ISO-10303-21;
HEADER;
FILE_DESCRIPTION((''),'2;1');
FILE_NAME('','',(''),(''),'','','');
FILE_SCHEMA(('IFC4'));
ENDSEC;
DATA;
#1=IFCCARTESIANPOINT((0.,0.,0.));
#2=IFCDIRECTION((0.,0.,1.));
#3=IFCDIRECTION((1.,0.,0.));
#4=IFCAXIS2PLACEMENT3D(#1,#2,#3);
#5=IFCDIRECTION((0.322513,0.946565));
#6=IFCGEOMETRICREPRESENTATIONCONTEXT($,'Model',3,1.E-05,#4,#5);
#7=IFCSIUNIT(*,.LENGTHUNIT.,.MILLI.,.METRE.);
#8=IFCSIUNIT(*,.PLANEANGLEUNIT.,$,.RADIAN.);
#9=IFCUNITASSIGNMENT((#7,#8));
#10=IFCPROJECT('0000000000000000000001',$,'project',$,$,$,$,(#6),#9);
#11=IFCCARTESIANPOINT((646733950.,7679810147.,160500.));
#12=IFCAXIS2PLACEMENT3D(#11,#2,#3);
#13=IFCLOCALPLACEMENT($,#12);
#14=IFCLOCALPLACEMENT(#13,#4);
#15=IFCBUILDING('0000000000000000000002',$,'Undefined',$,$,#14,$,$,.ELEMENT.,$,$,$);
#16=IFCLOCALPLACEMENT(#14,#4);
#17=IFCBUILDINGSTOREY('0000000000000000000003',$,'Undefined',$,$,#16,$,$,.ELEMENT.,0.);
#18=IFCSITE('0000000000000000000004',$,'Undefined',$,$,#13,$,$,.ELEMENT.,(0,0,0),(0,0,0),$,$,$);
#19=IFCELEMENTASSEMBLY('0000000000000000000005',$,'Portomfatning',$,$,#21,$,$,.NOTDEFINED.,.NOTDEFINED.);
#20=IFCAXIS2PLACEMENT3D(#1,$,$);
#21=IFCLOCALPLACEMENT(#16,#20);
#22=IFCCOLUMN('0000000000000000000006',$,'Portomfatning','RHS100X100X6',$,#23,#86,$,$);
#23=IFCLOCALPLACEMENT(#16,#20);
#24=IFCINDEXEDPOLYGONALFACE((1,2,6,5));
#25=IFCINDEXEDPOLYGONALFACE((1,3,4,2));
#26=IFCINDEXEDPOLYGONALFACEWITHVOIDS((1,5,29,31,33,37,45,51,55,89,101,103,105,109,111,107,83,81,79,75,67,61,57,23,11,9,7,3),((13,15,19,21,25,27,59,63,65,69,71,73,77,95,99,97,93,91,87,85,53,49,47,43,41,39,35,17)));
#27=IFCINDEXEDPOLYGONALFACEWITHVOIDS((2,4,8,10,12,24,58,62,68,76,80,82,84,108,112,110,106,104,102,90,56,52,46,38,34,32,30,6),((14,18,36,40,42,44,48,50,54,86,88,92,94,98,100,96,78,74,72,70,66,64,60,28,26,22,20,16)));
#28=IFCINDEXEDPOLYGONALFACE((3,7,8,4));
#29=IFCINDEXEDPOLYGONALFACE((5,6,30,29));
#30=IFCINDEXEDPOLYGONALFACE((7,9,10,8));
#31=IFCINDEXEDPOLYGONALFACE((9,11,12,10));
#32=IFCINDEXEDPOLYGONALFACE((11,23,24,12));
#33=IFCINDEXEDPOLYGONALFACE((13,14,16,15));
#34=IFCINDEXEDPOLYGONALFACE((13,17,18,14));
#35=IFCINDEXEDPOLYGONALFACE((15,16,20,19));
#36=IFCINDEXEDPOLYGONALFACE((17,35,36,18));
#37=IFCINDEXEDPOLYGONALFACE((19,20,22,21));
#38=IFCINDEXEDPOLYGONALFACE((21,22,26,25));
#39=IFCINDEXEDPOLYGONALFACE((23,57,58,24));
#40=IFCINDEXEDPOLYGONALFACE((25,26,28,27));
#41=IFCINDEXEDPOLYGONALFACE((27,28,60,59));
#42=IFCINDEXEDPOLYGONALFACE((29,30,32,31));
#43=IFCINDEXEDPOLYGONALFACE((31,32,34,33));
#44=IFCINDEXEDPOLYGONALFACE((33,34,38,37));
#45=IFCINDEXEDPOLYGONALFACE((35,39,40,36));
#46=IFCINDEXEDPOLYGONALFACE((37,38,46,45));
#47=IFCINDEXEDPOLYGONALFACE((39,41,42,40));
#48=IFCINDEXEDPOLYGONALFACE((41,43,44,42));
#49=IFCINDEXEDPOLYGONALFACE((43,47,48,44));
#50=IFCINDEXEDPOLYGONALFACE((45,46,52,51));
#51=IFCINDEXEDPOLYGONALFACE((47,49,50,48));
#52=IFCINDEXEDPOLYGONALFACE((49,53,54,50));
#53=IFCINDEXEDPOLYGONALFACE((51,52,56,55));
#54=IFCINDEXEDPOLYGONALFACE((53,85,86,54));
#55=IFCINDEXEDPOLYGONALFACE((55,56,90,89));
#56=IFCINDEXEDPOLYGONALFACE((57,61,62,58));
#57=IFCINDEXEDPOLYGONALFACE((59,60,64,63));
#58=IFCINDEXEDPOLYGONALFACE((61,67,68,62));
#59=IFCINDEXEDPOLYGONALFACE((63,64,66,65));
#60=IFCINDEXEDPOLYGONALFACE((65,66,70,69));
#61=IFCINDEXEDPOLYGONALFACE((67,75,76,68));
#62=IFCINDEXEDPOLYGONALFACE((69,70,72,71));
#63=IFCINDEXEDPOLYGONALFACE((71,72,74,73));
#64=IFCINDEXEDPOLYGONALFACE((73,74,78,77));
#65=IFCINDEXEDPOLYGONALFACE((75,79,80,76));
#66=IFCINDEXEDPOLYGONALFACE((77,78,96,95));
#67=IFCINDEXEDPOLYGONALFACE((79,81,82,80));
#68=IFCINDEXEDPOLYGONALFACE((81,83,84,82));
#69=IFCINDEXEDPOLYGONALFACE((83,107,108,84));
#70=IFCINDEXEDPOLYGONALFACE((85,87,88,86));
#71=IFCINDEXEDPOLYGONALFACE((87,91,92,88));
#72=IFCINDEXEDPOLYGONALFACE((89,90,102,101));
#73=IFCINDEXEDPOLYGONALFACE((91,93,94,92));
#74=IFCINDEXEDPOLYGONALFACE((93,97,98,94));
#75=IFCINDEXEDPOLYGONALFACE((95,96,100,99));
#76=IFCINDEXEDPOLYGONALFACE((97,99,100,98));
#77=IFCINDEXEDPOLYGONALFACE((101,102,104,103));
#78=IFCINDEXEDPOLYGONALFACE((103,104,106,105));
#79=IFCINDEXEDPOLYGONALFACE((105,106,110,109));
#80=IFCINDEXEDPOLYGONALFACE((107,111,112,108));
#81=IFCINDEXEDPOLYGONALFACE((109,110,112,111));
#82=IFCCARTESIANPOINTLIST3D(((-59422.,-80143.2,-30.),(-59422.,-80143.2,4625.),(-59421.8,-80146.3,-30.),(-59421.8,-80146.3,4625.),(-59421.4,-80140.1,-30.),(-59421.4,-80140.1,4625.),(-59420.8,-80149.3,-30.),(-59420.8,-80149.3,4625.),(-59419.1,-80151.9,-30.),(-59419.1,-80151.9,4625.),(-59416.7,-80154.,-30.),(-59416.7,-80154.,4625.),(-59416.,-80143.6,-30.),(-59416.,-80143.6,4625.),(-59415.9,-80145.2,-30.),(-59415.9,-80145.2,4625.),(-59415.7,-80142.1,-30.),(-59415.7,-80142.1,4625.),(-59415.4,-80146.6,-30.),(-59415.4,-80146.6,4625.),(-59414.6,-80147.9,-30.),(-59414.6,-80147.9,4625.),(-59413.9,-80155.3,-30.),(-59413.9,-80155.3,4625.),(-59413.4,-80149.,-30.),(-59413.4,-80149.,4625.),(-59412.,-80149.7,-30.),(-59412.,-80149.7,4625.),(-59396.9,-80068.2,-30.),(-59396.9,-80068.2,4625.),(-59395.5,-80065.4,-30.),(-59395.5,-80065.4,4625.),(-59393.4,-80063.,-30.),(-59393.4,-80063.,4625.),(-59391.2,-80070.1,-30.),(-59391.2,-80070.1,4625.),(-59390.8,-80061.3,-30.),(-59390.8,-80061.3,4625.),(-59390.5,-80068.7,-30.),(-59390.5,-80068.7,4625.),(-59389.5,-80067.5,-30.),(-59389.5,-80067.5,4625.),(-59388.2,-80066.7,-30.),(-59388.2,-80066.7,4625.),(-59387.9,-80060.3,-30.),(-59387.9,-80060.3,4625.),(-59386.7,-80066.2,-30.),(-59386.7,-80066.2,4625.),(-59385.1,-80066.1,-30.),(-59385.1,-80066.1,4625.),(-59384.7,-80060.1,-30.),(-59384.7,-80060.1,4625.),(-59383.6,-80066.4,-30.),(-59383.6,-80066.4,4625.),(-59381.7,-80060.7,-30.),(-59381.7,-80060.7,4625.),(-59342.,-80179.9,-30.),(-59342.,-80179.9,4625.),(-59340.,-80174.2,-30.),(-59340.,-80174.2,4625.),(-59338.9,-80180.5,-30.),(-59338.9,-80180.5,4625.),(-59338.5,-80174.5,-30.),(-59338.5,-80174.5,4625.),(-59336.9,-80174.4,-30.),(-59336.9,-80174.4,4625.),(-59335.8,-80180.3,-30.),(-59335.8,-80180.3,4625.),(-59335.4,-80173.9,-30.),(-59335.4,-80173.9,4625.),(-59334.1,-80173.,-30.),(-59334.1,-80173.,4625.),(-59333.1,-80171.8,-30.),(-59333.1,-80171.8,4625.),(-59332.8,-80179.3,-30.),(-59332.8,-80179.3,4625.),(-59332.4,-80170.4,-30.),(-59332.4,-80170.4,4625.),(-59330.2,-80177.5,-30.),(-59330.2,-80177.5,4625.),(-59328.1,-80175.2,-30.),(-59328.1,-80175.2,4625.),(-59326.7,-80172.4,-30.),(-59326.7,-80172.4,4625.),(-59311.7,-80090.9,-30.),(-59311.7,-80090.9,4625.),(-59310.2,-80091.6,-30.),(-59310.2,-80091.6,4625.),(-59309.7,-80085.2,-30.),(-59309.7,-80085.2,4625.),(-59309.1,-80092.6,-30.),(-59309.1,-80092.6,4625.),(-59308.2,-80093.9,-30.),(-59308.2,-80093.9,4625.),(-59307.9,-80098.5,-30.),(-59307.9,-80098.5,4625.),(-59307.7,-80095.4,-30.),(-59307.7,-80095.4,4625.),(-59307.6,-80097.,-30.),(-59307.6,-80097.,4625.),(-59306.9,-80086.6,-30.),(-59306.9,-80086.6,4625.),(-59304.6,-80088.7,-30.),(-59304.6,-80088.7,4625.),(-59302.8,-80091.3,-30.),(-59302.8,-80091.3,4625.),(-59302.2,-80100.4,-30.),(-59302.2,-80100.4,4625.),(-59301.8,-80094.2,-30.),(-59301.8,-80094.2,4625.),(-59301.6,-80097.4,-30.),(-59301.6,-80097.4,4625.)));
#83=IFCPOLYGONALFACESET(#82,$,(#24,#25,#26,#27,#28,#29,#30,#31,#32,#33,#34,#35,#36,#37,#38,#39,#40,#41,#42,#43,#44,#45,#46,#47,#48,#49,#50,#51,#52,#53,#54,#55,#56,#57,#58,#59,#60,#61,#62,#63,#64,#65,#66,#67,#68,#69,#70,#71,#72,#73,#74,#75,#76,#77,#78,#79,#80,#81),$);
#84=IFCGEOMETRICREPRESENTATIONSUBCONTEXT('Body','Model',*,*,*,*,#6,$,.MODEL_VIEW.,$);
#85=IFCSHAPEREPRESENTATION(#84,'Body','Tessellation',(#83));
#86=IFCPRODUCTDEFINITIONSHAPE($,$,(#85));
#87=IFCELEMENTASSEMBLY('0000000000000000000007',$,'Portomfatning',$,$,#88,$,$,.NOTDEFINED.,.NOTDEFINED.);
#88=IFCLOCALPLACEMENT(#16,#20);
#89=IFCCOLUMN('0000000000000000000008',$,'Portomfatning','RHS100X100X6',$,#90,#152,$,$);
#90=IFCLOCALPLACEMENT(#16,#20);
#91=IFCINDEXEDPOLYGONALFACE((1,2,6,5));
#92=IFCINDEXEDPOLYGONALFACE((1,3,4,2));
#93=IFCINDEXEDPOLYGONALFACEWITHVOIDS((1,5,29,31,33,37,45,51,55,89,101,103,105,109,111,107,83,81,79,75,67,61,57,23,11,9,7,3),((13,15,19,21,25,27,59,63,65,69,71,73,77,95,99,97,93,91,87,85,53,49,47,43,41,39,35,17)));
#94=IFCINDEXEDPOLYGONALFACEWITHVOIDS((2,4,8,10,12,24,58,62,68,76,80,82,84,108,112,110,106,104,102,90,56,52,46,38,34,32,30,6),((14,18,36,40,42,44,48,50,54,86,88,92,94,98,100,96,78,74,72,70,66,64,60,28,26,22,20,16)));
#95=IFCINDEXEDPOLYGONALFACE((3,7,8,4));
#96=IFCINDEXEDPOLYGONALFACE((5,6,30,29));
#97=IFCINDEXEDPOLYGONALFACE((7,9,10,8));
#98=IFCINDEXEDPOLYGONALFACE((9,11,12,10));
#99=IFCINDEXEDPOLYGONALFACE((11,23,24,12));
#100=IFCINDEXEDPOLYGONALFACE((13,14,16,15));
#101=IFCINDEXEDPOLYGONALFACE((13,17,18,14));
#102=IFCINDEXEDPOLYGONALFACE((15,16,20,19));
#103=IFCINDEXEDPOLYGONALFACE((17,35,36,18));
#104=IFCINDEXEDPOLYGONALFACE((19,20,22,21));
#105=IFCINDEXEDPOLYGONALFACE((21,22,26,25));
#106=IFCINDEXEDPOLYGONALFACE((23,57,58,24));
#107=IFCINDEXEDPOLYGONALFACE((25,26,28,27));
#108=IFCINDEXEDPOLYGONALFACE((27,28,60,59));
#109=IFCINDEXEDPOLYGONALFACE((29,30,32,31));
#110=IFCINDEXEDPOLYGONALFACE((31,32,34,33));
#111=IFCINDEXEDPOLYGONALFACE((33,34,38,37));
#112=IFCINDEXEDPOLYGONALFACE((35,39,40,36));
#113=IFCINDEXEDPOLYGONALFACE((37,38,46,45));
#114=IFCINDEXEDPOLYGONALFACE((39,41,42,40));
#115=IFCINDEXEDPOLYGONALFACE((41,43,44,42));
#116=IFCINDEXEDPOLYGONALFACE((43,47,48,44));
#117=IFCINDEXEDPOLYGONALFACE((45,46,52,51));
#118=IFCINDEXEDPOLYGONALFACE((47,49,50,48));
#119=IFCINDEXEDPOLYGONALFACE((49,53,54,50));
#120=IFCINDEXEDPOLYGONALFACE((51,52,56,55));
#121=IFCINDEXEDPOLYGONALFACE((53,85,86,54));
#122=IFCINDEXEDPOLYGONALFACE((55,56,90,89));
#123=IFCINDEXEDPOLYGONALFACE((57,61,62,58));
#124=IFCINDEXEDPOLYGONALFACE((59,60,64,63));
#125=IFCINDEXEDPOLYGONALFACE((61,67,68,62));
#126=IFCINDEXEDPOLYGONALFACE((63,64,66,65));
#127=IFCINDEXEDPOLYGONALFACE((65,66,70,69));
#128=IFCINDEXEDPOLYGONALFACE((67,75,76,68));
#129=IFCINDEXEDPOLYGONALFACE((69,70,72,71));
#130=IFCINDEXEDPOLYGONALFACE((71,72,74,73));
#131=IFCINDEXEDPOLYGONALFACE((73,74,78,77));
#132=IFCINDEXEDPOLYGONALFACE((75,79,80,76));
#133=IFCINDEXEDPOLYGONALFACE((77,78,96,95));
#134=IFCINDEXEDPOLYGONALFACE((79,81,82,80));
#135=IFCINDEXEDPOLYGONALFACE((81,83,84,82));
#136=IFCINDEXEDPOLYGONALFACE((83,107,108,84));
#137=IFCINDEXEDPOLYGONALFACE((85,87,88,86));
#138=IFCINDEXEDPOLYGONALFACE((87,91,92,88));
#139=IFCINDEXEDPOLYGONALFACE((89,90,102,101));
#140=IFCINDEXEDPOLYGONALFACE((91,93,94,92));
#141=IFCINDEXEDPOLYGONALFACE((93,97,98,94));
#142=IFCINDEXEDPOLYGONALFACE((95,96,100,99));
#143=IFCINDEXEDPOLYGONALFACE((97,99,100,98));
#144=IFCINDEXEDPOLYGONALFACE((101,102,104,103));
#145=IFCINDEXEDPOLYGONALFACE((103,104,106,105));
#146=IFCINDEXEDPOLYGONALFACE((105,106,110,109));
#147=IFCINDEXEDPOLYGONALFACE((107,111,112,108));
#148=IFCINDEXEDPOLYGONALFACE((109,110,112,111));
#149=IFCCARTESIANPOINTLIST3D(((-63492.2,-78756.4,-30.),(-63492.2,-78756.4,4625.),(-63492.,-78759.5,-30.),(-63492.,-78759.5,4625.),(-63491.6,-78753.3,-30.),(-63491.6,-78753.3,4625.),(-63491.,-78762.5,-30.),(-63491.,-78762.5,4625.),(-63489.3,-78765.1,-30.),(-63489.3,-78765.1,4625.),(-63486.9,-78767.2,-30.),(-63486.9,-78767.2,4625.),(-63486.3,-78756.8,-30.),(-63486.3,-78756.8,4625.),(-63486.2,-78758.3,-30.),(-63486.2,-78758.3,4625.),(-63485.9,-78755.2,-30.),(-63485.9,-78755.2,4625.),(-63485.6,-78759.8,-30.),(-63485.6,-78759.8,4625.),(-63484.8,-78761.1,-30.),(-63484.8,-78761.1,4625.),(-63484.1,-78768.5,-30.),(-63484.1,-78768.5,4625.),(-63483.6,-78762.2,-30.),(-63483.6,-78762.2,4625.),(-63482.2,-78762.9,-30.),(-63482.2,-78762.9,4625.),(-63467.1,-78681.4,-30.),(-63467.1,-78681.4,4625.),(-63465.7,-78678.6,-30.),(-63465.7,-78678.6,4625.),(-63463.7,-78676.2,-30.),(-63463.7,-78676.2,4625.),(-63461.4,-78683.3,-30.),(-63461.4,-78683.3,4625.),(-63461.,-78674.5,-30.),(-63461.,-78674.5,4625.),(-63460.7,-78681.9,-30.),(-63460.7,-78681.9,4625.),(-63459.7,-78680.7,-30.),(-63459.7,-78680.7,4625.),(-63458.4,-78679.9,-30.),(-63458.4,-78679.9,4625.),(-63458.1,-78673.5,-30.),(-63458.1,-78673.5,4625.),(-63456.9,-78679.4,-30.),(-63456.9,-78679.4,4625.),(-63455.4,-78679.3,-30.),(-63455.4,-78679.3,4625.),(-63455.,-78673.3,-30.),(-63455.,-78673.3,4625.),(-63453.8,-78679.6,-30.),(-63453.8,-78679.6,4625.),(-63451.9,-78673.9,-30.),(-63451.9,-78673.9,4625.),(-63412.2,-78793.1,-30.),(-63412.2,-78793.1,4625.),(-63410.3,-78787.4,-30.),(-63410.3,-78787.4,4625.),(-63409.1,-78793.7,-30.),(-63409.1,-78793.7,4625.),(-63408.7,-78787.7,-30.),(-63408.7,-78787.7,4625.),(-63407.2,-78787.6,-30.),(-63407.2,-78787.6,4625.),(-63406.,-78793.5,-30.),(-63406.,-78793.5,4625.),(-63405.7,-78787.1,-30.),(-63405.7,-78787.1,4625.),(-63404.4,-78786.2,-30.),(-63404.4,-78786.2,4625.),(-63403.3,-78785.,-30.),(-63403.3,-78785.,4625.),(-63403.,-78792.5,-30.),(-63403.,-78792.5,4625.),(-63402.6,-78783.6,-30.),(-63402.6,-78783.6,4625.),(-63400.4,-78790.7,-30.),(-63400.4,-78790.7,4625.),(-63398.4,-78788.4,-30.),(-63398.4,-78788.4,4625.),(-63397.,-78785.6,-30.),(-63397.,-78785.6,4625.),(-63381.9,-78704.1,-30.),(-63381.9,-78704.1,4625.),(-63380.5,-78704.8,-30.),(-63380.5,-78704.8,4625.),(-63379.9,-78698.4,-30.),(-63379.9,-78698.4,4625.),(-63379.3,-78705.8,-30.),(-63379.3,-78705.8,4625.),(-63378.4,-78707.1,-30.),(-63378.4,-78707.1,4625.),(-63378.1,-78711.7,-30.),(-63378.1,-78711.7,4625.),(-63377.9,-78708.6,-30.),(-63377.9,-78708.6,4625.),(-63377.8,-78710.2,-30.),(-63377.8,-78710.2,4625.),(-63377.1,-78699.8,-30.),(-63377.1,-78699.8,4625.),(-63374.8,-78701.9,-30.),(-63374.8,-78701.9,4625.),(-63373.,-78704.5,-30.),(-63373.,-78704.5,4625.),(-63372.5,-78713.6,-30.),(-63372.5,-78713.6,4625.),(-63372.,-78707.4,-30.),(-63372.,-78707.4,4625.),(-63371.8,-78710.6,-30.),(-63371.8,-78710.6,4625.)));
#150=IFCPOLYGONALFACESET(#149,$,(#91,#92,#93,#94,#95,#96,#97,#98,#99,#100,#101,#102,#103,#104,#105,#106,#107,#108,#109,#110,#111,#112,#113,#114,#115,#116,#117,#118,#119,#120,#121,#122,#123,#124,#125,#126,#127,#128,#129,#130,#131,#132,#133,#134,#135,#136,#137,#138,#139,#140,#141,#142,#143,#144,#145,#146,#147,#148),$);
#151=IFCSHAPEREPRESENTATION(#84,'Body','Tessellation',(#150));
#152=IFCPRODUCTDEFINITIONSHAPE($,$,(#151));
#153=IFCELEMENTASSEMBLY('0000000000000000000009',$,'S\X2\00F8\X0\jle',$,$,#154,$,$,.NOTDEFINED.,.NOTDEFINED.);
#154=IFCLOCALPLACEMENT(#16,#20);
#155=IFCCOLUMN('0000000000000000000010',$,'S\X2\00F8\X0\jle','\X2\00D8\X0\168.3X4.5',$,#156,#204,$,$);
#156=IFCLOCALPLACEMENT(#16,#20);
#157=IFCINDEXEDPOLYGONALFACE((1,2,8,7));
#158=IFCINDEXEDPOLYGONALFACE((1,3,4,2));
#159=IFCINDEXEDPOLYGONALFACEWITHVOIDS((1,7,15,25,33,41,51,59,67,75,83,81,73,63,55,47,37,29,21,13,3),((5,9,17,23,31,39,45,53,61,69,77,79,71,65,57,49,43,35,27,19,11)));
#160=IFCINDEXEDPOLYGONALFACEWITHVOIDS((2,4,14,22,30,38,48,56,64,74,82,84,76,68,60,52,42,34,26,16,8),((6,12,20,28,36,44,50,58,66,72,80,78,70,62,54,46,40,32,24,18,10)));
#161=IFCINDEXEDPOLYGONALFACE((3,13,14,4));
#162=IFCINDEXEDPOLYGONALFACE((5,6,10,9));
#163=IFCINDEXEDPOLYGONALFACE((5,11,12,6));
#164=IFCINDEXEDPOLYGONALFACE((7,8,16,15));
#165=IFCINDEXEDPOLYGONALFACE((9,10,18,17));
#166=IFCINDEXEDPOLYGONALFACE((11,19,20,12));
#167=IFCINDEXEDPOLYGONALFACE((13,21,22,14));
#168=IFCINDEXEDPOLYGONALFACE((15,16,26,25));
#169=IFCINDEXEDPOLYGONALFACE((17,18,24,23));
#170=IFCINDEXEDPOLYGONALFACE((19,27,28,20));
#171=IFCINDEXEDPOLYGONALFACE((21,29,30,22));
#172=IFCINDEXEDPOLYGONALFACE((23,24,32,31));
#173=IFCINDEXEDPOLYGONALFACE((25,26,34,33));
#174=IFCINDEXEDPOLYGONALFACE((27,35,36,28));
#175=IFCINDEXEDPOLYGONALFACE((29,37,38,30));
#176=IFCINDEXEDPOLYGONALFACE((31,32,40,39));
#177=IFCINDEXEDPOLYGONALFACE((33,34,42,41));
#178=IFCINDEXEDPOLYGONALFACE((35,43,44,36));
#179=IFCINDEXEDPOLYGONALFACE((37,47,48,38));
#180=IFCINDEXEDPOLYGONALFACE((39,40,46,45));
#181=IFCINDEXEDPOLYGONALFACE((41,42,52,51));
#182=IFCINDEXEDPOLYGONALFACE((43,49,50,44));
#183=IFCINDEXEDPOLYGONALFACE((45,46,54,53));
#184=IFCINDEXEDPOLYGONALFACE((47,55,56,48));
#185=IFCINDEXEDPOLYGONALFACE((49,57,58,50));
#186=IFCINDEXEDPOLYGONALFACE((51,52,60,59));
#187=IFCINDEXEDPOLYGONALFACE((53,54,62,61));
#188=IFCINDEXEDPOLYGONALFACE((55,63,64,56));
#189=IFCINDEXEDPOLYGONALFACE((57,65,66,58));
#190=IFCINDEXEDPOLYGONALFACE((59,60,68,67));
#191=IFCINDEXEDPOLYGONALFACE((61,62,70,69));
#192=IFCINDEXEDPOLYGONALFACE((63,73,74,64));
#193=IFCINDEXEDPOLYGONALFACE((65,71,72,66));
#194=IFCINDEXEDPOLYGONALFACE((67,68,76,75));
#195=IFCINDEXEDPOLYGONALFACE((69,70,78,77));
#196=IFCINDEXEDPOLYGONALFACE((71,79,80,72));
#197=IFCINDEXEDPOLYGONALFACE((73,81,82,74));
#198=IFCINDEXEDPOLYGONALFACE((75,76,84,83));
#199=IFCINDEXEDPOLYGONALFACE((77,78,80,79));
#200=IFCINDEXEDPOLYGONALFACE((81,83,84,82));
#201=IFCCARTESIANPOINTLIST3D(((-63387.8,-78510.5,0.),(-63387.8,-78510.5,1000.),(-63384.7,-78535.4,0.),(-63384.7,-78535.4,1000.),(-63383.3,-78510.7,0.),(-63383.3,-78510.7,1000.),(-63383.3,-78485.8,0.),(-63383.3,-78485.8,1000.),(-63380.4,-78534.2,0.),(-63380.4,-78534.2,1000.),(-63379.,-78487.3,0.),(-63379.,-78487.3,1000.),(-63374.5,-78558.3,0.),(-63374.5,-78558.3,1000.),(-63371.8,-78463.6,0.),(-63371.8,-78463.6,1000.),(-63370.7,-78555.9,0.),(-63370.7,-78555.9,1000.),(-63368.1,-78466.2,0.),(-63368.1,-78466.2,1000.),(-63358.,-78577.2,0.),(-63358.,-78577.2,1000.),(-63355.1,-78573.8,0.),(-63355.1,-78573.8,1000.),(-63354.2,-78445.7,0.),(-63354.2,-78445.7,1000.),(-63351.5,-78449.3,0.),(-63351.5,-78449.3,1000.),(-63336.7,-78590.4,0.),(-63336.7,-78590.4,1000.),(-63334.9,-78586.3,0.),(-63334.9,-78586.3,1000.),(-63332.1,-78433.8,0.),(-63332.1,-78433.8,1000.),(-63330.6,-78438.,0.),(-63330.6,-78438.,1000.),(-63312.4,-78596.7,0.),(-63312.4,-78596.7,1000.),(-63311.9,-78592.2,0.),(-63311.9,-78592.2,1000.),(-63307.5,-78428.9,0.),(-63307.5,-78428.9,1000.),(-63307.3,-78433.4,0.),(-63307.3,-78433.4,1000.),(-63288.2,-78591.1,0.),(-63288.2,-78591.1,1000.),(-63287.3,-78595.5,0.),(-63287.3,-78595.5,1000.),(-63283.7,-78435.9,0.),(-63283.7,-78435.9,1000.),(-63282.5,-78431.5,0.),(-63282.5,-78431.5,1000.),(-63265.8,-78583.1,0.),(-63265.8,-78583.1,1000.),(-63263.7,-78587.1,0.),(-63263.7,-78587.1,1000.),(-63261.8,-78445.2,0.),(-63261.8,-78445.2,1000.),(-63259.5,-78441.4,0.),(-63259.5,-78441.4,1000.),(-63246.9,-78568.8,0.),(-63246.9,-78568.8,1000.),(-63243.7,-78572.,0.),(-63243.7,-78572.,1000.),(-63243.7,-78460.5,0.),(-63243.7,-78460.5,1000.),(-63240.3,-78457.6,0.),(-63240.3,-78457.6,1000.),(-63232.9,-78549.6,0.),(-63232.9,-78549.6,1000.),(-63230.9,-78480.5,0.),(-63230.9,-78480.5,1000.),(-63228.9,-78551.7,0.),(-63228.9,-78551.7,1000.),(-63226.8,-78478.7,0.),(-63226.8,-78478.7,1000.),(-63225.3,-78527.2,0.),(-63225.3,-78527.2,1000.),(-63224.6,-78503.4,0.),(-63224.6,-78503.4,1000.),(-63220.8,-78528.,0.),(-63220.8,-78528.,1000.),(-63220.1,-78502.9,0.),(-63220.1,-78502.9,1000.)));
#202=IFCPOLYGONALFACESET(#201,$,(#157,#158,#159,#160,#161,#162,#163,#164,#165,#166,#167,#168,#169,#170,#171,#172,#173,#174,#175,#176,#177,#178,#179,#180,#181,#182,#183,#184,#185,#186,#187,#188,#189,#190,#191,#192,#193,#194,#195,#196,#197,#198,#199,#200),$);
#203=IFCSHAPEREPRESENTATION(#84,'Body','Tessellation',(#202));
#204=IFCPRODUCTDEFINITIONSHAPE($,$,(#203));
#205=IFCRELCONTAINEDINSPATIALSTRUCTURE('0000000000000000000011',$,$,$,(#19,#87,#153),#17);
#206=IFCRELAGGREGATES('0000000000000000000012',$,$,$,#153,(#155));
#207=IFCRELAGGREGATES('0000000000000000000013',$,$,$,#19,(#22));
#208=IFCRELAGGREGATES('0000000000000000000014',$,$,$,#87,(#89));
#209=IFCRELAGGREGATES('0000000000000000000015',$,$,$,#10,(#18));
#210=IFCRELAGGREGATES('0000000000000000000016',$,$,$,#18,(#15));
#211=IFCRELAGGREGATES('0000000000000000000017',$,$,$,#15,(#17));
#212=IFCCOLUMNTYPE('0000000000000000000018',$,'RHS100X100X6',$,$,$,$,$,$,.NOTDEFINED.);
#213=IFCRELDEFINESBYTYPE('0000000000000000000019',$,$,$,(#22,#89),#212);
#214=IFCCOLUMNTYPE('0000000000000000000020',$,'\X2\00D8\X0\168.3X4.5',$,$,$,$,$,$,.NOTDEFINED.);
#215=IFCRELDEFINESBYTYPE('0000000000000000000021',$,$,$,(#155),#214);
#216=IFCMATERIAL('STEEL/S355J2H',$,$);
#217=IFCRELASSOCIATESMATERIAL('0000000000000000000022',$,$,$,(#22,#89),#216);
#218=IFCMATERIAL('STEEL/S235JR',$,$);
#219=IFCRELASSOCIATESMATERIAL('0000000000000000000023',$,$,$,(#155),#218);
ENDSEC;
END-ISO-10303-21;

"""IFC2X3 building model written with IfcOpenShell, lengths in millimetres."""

from ifc_helpers import new_model, si_unit, direction, frame, origin_with_axes, origin_2d_with_axis, place, context, subcontext, project, spatial, hollow_rectangle, hollow_circle, extrude, material, type_object, element, aggregate, save


model = new_model("IFC2X3")

# Units and contexts
model_context = context("Model", 3, precision=1e-05, world=origin_with_axes(), true_north=direction((0.322513, 0.946565)))
body_context = subcontext(model_context, "Body", "Model", "MODEL_VIEW")
ifc_project = project(units=[si_unit("LENGTHUNIT", "METRE", prefix="MILLI"), si_unit("PLANEANGLEUNIT", "RADIAN")], contexts=[model_context])

# Site, building, storey
site_placement = place(None, frame((646733950.0, 7679810147.0, 160500.0), z_axis=(0.0, 0.0, 1.0), x_axis=(1.0, 0.0, 0.0)))
site = spatial("IfcSite", under=ifc_project, at=site_placement, Name="Undefined", CompositionType="ELEMENT", RefLatitude=(0, 0, 0), RefLongitude=(0, 0, 0))
building_placement = place(site_placement, origin_with_axes())
building = spatial("IfcBuilding", under=site, at=building_placement, Name="Undefined", CompositionType="ELEMENT")
storey_placement = place(building_placement, origin_with_axes())
storey = spatial("IfcBuildingStorey", under=building, at=storey_placement, Name="Undefined", CompositionType="ELEMENT", Elevation=0.0)

# Element assemblies, columns
ifc_material_1 = material(Name="STEEL/S355J2H")
column_type_1 = type_object("IfcColumnType", Name="RHS100X100X6", PredefinedType="NOTDEFINED")
assembly_1_placement = place(storey_placement, origin_with_axes())
assembly_1 = element("IfcElementAssembly", 1, at=assembly_1_placement, inside=storey, Name="Portomfatning", AssemblyPlace="NOTDEFINED", PredefinedType="NOTDEFINED")
column_1_placement = place(assembly_1_placement, frame((-59361.8, -80120.3, -30.0), z_axis=(0.0, 0.0, 1.0), x_axis=(-0.946565, 0.322513, 0.0)))
column_1 = element("IfcColumn", 2, at=column_1_placement, type_object=column_type_1, material=ifc_material_1, Name="Portomfatning", Description="RHS100X100X6", context=body_context, shape_type="SweptSolid", body=[
    extrude(hollow_rectangle(XDim=100.0, YDim=100.0, WallThickness=6.0, InnerFilletRadius=6.0, OuterFilletRadius=12.0, at=origin_2d_with_axis()), frame((0.0, 0.0, 4655.0), z_axis=(0.0, 0.0, -1.0), x_axis=(0.0, 1.0, 0.0)), (0.0, 0.0, 1.0), 4655.0),
])
assembly_2_placement = place(storey_placement, origin_with_axes())
assembly_2 = element("IfcElementAssembly", 3, at=assembly_2_placement, inside=storey, Name="Portomfatning", AssemblyPlace="NOTDEFINED", PredefinedType="NOTDEFINED")
column_2_placement = place(assembly_2_placement, frame((-63432.0, -78733.5, -30.0), z_axis=(0.0, 0.0, 1.0), x_axis=(-0.946565, 0.322513, 0.0)))
column_2 = element("IfcColumn", 4, at=column_2_placement, type_object=column_type_1, material=ifc_material_1, Name="Portomfatning", Description="RHS100X100X6", context=body_context, shape_type="SweptSolid", body=[
    extrude(hollow_rectangle(XDim=100.0, YDim=100.0, WallThickness=6.0, InnerFilletRadius=6.0, OuterFilletRadius=12.0, at=origin_2d_with_axis()), frame((0.0, 0.0, 4655.0), z_axis=(0.0, 0.0, -1.0), x_axis=(0.0, 1.0, 0.0)), (0.0, 0.0, 1.0), 4655.0),
])
assembly_3_placement = place(storey_placement, origin_with_axes())
assembly_3 = element("IfcElementAssembly", 5, at=assembly_3_placement, inside=storey, Name="Søjle", AssemblyPlace="NOTDEFINED", PredefinedType="NOTDEFINED")
ifc_material_2 = material(Name="STEEL/S235JR")
column_type_2 = type_object("IfcColumnType", Name="Ø168.3X4.5", PredefinedType="NOTDEFINED")
column_3_placement = place(assembly_3_placement, frame((-63303.6, -78513.0, 0.0), z_axis=(0.0, 0.0, 1.0), x_axis=(0.322513, 0.946565, 0.0)))
column_3 = element("IfcColumn", 6, at=column_3_placement, type_object=column_type_2, material=ifc_material_2, Name="Søjle", Description="Ø168.3X4.5", context=body_context, shape_type="SweptSolid", body=[
    extrude(hollow_circle(Radius=84.2, WallThickness=4.5, at=origin_2d_with_axis()), frame((0.0, 0.0, 1000.0), z_axis=(0.0, 0.0, -1.0), x_axis=(0.0, 1.0, 0.0)), (0.0, 0.0, 1.0), 1000.0),
])
aggregate(assembly_3, [column_3])

aggregate(assembly_1, [column_1])

aggregate(assembly_2, [column_2])

save(model, "model.ifc")
